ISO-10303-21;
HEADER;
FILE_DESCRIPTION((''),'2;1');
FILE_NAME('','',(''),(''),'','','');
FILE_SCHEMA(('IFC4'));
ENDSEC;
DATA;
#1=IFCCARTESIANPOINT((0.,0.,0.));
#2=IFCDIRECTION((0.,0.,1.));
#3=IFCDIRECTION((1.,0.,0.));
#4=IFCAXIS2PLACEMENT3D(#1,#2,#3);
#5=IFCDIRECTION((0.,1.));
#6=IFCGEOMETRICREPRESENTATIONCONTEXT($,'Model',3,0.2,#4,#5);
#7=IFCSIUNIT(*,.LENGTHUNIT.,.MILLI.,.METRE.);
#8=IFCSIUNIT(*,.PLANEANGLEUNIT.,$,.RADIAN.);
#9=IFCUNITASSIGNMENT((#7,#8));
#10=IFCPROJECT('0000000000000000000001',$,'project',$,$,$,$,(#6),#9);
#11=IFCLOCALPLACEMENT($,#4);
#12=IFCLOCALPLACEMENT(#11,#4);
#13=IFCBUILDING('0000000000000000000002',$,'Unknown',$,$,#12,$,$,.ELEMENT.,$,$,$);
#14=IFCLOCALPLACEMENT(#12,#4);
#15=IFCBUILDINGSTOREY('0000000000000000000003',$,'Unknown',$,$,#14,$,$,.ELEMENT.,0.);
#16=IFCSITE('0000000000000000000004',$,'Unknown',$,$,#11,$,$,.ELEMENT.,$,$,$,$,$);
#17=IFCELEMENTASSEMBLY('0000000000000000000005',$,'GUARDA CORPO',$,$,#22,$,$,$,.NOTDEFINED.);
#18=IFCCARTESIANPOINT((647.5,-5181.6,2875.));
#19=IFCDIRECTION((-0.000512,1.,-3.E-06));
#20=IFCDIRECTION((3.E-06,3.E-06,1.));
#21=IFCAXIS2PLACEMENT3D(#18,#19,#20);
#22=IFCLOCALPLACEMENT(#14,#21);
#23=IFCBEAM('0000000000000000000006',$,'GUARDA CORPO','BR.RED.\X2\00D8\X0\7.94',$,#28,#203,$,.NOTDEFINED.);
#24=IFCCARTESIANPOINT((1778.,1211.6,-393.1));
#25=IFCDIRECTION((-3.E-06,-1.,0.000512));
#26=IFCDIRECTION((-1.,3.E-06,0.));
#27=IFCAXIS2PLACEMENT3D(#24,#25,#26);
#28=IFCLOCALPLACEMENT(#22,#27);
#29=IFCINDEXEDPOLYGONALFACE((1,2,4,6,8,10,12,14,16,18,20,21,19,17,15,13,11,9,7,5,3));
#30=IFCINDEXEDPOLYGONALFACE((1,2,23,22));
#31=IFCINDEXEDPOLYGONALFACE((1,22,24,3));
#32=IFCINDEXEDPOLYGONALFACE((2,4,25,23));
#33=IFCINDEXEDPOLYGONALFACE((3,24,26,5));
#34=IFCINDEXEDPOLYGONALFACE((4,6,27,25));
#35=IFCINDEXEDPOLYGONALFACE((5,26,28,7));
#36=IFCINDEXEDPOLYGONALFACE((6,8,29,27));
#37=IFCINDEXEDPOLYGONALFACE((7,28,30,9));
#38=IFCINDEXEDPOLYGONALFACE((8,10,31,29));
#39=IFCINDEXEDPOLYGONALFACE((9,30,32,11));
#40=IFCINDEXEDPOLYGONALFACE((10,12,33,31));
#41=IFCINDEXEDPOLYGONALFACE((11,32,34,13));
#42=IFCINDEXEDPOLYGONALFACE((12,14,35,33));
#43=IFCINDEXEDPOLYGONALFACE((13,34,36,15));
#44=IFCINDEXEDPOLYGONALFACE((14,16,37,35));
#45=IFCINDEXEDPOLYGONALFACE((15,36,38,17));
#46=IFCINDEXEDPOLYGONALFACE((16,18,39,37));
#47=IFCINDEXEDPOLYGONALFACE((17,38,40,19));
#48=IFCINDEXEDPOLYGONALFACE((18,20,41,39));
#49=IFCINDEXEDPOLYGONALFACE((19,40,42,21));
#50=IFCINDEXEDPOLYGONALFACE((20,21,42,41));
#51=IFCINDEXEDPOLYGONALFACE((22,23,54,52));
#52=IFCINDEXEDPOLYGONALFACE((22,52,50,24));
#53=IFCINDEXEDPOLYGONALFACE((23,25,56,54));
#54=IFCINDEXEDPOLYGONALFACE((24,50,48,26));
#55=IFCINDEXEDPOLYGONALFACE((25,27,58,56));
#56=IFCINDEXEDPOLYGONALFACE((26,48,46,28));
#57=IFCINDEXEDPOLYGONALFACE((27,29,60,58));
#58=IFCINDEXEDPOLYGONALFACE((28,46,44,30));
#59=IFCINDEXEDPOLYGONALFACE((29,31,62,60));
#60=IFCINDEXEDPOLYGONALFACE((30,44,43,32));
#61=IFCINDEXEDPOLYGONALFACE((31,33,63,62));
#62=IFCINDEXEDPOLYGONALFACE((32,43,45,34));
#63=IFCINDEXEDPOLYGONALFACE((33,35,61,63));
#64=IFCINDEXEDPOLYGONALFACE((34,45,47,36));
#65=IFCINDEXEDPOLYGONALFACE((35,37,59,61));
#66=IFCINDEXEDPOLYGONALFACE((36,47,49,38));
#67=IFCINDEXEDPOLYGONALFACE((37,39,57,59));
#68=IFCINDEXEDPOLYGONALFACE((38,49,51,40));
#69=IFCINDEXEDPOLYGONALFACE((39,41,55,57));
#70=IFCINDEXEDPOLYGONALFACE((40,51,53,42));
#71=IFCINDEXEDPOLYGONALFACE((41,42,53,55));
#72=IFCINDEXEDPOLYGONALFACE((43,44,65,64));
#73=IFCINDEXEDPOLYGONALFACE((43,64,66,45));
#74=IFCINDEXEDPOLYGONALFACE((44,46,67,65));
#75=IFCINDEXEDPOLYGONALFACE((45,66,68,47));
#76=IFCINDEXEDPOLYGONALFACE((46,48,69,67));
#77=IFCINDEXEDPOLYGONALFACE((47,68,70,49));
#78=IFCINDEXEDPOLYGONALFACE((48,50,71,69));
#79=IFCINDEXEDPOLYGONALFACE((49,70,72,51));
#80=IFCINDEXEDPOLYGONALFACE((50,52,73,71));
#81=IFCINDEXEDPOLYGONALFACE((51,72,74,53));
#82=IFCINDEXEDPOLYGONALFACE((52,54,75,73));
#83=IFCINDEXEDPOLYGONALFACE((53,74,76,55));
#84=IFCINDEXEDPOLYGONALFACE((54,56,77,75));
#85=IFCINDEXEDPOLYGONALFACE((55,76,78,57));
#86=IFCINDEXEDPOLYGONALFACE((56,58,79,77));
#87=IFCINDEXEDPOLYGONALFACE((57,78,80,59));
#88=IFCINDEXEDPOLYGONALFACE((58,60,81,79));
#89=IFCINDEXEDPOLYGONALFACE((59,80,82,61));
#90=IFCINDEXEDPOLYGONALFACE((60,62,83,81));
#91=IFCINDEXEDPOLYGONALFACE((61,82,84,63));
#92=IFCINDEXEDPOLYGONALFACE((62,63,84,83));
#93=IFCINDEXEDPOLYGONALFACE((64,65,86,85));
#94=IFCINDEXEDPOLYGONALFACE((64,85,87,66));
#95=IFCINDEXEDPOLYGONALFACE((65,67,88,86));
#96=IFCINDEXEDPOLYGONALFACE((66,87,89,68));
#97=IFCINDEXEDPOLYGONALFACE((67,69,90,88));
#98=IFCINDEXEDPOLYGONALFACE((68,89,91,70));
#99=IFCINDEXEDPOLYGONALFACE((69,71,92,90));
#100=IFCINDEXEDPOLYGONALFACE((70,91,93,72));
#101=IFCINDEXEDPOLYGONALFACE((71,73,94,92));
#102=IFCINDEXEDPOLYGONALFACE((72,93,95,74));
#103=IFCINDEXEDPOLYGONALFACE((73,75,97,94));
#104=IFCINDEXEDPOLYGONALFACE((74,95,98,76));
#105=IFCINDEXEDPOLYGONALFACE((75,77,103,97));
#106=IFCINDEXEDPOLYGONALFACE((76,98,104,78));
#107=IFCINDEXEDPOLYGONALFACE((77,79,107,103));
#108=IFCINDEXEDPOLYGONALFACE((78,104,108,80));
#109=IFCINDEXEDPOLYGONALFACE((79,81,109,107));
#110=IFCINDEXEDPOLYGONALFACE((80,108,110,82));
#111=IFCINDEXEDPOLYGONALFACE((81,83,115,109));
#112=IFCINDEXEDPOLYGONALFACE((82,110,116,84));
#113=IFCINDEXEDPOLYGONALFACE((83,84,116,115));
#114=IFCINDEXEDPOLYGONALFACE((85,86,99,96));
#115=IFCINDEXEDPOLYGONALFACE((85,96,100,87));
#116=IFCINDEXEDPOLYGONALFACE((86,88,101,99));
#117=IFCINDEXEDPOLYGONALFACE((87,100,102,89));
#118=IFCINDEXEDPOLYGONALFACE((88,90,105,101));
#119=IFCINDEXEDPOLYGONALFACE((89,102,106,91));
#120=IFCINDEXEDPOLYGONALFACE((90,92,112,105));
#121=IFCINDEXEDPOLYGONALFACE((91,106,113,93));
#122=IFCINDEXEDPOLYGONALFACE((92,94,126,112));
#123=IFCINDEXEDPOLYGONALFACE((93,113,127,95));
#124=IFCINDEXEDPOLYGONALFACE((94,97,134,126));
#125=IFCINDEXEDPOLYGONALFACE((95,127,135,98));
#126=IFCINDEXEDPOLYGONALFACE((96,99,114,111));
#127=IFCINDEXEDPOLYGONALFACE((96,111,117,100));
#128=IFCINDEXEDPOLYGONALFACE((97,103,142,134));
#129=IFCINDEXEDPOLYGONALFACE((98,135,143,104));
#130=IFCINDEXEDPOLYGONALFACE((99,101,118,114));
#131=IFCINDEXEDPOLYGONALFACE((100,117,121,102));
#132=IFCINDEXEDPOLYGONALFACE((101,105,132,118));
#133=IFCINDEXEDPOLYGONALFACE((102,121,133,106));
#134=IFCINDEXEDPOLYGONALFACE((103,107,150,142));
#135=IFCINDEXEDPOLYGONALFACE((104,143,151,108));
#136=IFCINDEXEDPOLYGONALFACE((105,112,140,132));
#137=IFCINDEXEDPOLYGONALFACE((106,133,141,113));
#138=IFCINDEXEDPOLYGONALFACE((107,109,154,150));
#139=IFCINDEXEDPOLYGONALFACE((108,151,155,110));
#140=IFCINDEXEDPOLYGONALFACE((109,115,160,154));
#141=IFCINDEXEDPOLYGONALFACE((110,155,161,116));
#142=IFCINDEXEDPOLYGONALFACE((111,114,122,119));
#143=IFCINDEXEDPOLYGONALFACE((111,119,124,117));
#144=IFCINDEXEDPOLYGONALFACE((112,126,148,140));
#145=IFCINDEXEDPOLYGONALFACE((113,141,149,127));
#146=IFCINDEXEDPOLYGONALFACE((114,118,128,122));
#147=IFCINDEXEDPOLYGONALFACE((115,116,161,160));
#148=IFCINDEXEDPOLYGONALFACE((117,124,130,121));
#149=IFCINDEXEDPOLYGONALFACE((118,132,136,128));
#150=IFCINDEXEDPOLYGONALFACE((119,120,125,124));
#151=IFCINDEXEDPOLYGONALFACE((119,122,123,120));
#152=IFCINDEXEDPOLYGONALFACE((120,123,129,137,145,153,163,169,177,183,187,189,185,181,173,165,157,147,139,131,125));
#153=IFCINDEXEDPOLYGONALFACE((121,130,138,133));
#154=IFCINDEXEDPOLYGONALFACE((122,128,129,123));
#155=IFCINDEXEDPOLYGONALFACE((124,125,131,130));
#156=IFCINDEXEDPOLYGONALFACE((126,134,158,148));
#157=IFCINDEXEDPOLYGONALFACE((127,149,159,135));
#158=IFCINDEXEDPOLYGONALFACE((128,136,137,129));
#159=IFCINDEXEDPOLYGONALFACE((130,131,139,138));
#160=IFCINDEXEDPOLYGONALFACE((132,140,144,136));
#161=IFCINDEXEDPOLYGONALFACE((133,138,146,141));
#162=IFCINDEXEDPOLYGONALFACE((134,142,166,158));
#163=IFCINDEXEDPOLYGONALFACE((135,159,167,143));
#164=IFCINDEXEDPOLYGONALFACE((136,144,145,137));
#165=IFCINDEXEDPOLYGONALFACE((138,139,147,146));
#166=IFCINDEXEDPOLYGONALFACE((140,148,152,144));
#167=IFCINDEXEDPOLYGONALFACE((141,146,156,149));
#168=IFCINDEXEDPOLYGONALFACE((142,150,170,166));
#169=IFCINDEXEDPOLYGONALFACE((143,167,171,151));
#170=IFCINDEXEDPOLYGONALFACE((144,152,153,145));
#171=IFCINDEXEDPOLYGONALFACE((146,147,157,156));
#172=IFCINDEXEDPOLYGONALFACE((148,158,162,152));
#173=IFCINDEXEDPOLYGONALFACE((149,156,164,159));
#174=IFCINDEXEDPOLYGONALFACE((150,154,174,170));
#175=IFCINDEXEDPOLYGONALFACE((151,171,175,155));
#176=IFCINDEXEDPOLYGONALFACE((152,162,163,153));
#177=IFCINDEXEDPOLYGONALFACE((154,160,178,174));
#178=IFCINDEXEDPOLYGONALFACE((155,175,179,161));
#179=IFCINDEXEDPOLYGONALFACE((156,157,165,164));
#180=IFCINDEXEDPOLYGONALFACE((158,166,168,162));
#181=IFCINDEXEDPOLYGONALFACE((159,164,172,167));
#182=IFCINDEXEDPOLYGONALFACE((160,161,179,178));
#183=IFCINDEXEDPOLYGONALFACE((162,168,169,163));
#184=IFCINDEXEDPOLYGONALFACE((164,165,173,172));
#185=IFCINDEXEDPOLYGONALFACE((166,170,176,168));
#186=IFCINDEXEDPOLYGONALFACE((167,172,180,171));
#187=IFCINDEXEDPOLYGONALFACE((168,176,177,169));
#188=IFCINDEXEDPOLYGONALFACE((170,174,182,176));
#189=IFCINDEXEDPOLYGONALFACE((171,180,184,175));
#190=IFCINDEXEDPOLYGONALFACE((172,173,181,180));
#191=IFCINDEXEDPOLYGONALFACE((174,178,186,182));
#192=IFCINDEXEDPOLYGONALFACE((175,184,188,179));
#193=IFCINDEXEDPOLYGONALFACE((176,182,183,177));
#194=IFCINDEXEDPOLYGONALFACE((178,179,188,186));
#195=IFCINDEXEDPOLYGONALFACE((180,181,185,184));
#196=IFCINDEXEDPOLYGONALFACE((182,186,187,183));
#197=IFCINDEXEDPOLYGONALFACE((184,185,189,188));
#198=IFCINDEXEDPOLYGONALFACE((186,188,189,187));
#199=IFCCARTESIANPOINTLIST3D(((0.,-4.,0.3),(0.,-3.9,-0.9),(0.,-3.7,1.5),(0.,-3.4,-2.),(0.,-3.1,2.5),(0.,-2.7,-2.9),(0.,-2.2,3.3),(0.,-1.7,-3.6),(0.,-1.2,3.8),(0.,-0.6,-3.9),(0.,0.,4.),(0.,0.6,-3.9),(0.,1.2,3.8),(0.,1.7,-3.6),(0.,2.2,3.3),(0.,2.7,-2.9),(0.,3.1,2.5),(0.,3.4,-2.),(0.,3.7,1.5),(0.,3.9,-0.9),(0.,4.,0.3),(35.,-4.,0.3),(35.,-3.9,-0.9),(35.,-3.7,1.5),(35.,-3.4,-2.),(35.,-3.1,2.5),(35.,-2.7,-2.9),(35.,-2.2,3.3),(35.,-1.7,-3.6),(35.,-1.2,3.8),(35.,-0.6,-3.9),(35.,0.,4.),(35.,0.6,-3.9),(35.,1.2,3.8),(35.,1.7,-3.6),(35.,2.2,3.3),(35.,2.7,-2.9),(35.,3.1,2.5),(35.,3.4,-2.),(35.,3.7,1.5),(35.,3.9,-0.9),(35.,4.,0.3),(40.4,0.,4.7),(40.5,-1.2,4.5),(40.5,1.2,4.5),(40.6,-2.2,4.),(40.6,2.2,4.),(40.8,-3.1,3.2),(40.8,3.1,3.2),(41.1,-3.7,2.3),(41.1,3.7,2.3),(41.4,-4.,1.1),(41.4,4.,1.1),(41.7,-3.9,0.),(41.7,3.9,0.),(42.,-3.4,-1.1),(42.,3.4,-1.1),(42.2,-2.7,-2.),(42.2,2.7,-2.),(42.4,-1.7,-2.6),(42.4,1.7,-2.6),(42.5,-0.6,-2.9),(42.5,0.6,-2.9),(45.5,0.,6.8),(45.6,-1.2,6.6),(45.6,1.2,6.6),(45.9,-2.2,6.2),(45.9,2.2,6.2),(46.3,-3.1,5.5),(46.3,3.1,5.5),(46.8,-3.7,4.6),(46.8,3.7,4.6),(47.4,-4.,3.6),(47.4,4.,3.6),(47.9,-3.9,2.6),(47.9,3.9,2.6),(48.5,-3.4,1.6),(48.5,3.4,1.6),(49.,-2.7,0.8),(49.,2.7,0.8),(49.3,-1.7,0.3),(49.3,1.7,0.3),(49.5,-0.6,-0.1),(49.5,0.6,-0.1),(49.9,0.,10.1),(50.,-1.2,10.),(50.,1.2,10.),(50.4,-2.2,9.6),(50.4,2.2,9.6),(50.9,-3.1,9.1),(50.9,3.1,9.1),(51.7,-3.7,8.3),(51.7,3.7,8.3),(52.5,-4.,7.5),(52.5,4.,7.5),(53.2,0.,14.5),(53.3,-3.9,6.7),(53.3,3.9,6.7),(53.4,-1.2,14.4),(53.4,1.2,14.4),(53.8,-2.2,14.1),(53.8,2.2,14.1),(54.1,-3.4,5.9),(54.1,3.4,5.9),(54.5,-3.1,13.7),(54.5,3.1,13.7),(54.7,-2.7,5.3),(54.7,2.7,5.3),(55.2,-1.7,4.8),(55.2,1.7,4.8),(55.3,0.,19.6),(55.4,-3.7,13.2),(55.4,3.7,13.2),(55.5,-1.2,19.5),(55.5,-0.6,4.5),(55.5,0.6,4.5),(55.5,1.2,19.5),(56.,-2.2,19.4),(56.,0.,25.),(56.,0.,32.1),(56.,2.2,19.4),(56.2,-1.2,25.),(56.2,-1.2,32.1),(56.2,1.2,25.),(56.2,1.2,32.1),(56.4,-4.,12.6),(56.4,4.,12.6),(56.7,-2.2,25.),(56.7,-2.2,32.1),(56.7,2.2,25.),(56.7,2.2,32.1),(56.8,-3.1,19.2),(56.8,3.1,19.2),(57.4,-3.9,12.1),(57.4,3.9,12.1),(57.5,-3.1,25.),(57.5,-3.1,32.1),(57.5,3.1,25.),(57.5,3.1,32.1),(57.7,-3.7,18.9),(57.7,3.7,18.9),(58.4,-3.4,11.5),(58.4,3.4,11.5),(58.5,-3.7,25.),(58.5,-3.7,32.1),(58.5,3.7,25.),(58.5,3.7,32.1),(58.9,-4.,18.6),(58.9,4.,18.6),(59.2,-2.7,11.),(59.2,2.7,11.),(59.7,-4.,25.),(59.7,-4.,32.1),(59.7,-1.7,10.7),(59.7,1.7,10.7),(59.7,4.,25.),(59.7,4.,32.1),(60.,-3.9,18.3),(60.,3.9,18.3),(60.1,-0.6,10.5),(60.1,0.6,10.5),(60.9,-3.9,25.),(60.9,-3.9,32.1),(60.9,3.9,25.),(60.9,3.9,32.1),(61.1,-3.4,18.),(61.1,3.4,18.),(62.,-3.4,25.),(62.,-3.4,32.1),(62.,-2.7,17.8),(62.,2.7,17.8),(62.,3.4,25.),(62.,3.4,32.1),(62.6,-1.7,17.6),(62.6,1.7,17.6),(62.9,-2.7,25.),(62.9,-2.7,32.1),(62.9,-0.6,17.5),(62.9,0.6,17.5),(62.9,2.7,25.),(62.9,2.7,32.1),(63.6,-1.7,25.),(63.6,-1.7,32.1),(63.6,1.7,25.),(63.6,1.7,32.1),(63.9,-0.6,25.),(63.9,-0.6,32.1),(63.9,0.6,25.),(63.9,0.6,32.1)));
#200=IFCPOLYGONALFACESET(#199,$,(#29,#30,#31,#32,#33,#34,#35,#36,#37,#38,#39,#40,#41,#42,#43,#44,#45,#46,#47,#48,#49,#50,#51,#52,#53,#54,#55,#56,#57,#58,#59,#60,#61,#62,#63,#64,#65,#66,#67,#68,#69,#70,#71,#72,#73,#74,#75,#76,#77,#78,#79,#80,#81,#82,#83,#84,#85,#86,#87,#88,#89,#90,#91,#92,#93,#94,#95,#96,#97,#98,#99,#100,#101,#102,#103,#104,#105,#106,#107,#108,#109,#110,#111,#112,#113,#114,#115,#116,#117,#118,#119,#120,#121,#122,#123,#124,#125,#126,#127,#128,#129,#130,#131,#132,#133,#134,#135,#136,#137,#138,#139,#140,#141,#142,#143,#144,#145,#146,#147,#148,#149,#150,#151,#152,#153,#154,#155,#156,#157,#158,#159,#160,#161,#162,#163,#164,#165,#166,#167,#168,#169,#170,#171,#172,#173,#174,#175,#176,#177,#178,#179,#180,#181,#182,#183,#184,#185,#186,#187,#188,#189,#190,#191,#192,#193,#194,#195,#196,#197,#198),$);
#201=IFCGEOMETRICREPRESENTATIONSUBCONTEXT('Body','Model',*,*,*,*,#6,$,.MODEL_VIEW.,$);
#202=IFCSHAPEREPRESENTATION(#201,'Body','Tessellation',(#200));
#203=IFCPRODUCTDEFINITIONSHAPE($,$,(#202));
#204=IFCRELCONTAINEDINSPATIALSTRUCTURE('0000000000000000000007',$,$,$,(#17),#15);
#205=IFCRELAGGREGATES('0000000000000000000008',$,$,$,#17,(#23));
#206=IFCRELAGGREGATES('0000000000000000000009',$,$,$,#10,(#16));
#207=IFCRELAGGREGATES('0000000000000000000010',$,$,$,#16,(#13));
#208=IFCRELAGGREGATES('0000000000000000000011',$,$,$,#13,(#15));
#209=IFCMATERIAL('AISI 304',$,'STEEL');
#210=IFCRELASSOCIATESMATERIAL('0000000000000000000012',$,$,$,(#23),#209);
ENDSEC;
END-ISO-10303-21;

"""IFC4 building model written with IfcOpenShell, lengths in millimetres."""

from ifc_helpers import new_model, entity, si_unit, direction, frame, origin_with_axes, place, context, subcontext, project, spatial, material, element, aggregate, save


model = new_model("IFC4")

# Units and contexts
model_context = context("Model", 3, precision=0.2, world=origin_with_axes(), true_north=direction((0.0, 1.0)))
body_context = subcontext(model_context, "Body", "Model", "MODEL_VIEW")
ifc_project = project(units=[si_unit("LENGTHUNIT", "METRE", prefix="MILLI"), si_unit("PLANEANGLEUNIT", "RADIAN")], contexts=[model_context])

# Site, building, storey
site_placement = place(None, origin_with_axes())
site = spatial("IfcSite", under=ifc_project, at=site_placement, Name="Unknown", CompositionType="ELEMENT")
building_placement = place(site_placement, origin_with_axes())
building = spatial("IfcBuilding", under=site, at=building_placement, Name="Unknown", CompositionType="ELEMENT")
storey_placement = place(building_placement, origin_with_axes())
storey = spatial("IfcBuildingStorey", under=building, at=storey_placement, Name="Unknown", CompositionType="ELEMENT", Elevation=0.0)

# Element assembly, beam
assembly_1_placement = place(storey_placement, frame((647.5, -5181.6, 2875.0), z_axis=(-0.000512, 1.0, -0.000003), x_axis=(0.000003, 0.000003, 1.0)))
assembly_1 = element("IfcElementAssembly", 1, at=assembly_1_placement, inside=storey, Name="GUARDA CORPO", PredefinedType="NOTDEFINED")
ifc_material_1 = material(Name="AISI 304", Category="STEEL")
beam_1_placement = place(assembly_1_placement, frame((1778.0, 1211.6, -393.1), z_axis=(-0.000003, -1.0, 0.000512), x_axis=(-1.0, 0.000003, 0.0)))
beam_1 = element("IfcBeam", 2, at=beam_1_placement, material=ifc_material_1, Name="GUARDA CORPO", Description="BR.RED.Ø7.94", PredefinedType="NOTDEFINED", context=body_context, shape_type="SolidModel", body=[
    entity("IfcSweptDiskSolid", entity("IfcIndexedPolyCurve", entity("IfcCartesianPointList3D", [[0.0, 0.0, 0.0], [35.0, 0.0, 0.0], [52.7, 0.0, 7.3], [60.0, 0.0, 25.0], [60.0, 0.0, 32.1]]), [entity("IfcLineIndex", [1, 2]), entity("IfcArcIndex", [2, 3, 4]), entity("IfcLineIndex", [4, 5])]), 4.0),
])

aggregate(assembly_1, [beam_1])

save(model, "model.ifc")
